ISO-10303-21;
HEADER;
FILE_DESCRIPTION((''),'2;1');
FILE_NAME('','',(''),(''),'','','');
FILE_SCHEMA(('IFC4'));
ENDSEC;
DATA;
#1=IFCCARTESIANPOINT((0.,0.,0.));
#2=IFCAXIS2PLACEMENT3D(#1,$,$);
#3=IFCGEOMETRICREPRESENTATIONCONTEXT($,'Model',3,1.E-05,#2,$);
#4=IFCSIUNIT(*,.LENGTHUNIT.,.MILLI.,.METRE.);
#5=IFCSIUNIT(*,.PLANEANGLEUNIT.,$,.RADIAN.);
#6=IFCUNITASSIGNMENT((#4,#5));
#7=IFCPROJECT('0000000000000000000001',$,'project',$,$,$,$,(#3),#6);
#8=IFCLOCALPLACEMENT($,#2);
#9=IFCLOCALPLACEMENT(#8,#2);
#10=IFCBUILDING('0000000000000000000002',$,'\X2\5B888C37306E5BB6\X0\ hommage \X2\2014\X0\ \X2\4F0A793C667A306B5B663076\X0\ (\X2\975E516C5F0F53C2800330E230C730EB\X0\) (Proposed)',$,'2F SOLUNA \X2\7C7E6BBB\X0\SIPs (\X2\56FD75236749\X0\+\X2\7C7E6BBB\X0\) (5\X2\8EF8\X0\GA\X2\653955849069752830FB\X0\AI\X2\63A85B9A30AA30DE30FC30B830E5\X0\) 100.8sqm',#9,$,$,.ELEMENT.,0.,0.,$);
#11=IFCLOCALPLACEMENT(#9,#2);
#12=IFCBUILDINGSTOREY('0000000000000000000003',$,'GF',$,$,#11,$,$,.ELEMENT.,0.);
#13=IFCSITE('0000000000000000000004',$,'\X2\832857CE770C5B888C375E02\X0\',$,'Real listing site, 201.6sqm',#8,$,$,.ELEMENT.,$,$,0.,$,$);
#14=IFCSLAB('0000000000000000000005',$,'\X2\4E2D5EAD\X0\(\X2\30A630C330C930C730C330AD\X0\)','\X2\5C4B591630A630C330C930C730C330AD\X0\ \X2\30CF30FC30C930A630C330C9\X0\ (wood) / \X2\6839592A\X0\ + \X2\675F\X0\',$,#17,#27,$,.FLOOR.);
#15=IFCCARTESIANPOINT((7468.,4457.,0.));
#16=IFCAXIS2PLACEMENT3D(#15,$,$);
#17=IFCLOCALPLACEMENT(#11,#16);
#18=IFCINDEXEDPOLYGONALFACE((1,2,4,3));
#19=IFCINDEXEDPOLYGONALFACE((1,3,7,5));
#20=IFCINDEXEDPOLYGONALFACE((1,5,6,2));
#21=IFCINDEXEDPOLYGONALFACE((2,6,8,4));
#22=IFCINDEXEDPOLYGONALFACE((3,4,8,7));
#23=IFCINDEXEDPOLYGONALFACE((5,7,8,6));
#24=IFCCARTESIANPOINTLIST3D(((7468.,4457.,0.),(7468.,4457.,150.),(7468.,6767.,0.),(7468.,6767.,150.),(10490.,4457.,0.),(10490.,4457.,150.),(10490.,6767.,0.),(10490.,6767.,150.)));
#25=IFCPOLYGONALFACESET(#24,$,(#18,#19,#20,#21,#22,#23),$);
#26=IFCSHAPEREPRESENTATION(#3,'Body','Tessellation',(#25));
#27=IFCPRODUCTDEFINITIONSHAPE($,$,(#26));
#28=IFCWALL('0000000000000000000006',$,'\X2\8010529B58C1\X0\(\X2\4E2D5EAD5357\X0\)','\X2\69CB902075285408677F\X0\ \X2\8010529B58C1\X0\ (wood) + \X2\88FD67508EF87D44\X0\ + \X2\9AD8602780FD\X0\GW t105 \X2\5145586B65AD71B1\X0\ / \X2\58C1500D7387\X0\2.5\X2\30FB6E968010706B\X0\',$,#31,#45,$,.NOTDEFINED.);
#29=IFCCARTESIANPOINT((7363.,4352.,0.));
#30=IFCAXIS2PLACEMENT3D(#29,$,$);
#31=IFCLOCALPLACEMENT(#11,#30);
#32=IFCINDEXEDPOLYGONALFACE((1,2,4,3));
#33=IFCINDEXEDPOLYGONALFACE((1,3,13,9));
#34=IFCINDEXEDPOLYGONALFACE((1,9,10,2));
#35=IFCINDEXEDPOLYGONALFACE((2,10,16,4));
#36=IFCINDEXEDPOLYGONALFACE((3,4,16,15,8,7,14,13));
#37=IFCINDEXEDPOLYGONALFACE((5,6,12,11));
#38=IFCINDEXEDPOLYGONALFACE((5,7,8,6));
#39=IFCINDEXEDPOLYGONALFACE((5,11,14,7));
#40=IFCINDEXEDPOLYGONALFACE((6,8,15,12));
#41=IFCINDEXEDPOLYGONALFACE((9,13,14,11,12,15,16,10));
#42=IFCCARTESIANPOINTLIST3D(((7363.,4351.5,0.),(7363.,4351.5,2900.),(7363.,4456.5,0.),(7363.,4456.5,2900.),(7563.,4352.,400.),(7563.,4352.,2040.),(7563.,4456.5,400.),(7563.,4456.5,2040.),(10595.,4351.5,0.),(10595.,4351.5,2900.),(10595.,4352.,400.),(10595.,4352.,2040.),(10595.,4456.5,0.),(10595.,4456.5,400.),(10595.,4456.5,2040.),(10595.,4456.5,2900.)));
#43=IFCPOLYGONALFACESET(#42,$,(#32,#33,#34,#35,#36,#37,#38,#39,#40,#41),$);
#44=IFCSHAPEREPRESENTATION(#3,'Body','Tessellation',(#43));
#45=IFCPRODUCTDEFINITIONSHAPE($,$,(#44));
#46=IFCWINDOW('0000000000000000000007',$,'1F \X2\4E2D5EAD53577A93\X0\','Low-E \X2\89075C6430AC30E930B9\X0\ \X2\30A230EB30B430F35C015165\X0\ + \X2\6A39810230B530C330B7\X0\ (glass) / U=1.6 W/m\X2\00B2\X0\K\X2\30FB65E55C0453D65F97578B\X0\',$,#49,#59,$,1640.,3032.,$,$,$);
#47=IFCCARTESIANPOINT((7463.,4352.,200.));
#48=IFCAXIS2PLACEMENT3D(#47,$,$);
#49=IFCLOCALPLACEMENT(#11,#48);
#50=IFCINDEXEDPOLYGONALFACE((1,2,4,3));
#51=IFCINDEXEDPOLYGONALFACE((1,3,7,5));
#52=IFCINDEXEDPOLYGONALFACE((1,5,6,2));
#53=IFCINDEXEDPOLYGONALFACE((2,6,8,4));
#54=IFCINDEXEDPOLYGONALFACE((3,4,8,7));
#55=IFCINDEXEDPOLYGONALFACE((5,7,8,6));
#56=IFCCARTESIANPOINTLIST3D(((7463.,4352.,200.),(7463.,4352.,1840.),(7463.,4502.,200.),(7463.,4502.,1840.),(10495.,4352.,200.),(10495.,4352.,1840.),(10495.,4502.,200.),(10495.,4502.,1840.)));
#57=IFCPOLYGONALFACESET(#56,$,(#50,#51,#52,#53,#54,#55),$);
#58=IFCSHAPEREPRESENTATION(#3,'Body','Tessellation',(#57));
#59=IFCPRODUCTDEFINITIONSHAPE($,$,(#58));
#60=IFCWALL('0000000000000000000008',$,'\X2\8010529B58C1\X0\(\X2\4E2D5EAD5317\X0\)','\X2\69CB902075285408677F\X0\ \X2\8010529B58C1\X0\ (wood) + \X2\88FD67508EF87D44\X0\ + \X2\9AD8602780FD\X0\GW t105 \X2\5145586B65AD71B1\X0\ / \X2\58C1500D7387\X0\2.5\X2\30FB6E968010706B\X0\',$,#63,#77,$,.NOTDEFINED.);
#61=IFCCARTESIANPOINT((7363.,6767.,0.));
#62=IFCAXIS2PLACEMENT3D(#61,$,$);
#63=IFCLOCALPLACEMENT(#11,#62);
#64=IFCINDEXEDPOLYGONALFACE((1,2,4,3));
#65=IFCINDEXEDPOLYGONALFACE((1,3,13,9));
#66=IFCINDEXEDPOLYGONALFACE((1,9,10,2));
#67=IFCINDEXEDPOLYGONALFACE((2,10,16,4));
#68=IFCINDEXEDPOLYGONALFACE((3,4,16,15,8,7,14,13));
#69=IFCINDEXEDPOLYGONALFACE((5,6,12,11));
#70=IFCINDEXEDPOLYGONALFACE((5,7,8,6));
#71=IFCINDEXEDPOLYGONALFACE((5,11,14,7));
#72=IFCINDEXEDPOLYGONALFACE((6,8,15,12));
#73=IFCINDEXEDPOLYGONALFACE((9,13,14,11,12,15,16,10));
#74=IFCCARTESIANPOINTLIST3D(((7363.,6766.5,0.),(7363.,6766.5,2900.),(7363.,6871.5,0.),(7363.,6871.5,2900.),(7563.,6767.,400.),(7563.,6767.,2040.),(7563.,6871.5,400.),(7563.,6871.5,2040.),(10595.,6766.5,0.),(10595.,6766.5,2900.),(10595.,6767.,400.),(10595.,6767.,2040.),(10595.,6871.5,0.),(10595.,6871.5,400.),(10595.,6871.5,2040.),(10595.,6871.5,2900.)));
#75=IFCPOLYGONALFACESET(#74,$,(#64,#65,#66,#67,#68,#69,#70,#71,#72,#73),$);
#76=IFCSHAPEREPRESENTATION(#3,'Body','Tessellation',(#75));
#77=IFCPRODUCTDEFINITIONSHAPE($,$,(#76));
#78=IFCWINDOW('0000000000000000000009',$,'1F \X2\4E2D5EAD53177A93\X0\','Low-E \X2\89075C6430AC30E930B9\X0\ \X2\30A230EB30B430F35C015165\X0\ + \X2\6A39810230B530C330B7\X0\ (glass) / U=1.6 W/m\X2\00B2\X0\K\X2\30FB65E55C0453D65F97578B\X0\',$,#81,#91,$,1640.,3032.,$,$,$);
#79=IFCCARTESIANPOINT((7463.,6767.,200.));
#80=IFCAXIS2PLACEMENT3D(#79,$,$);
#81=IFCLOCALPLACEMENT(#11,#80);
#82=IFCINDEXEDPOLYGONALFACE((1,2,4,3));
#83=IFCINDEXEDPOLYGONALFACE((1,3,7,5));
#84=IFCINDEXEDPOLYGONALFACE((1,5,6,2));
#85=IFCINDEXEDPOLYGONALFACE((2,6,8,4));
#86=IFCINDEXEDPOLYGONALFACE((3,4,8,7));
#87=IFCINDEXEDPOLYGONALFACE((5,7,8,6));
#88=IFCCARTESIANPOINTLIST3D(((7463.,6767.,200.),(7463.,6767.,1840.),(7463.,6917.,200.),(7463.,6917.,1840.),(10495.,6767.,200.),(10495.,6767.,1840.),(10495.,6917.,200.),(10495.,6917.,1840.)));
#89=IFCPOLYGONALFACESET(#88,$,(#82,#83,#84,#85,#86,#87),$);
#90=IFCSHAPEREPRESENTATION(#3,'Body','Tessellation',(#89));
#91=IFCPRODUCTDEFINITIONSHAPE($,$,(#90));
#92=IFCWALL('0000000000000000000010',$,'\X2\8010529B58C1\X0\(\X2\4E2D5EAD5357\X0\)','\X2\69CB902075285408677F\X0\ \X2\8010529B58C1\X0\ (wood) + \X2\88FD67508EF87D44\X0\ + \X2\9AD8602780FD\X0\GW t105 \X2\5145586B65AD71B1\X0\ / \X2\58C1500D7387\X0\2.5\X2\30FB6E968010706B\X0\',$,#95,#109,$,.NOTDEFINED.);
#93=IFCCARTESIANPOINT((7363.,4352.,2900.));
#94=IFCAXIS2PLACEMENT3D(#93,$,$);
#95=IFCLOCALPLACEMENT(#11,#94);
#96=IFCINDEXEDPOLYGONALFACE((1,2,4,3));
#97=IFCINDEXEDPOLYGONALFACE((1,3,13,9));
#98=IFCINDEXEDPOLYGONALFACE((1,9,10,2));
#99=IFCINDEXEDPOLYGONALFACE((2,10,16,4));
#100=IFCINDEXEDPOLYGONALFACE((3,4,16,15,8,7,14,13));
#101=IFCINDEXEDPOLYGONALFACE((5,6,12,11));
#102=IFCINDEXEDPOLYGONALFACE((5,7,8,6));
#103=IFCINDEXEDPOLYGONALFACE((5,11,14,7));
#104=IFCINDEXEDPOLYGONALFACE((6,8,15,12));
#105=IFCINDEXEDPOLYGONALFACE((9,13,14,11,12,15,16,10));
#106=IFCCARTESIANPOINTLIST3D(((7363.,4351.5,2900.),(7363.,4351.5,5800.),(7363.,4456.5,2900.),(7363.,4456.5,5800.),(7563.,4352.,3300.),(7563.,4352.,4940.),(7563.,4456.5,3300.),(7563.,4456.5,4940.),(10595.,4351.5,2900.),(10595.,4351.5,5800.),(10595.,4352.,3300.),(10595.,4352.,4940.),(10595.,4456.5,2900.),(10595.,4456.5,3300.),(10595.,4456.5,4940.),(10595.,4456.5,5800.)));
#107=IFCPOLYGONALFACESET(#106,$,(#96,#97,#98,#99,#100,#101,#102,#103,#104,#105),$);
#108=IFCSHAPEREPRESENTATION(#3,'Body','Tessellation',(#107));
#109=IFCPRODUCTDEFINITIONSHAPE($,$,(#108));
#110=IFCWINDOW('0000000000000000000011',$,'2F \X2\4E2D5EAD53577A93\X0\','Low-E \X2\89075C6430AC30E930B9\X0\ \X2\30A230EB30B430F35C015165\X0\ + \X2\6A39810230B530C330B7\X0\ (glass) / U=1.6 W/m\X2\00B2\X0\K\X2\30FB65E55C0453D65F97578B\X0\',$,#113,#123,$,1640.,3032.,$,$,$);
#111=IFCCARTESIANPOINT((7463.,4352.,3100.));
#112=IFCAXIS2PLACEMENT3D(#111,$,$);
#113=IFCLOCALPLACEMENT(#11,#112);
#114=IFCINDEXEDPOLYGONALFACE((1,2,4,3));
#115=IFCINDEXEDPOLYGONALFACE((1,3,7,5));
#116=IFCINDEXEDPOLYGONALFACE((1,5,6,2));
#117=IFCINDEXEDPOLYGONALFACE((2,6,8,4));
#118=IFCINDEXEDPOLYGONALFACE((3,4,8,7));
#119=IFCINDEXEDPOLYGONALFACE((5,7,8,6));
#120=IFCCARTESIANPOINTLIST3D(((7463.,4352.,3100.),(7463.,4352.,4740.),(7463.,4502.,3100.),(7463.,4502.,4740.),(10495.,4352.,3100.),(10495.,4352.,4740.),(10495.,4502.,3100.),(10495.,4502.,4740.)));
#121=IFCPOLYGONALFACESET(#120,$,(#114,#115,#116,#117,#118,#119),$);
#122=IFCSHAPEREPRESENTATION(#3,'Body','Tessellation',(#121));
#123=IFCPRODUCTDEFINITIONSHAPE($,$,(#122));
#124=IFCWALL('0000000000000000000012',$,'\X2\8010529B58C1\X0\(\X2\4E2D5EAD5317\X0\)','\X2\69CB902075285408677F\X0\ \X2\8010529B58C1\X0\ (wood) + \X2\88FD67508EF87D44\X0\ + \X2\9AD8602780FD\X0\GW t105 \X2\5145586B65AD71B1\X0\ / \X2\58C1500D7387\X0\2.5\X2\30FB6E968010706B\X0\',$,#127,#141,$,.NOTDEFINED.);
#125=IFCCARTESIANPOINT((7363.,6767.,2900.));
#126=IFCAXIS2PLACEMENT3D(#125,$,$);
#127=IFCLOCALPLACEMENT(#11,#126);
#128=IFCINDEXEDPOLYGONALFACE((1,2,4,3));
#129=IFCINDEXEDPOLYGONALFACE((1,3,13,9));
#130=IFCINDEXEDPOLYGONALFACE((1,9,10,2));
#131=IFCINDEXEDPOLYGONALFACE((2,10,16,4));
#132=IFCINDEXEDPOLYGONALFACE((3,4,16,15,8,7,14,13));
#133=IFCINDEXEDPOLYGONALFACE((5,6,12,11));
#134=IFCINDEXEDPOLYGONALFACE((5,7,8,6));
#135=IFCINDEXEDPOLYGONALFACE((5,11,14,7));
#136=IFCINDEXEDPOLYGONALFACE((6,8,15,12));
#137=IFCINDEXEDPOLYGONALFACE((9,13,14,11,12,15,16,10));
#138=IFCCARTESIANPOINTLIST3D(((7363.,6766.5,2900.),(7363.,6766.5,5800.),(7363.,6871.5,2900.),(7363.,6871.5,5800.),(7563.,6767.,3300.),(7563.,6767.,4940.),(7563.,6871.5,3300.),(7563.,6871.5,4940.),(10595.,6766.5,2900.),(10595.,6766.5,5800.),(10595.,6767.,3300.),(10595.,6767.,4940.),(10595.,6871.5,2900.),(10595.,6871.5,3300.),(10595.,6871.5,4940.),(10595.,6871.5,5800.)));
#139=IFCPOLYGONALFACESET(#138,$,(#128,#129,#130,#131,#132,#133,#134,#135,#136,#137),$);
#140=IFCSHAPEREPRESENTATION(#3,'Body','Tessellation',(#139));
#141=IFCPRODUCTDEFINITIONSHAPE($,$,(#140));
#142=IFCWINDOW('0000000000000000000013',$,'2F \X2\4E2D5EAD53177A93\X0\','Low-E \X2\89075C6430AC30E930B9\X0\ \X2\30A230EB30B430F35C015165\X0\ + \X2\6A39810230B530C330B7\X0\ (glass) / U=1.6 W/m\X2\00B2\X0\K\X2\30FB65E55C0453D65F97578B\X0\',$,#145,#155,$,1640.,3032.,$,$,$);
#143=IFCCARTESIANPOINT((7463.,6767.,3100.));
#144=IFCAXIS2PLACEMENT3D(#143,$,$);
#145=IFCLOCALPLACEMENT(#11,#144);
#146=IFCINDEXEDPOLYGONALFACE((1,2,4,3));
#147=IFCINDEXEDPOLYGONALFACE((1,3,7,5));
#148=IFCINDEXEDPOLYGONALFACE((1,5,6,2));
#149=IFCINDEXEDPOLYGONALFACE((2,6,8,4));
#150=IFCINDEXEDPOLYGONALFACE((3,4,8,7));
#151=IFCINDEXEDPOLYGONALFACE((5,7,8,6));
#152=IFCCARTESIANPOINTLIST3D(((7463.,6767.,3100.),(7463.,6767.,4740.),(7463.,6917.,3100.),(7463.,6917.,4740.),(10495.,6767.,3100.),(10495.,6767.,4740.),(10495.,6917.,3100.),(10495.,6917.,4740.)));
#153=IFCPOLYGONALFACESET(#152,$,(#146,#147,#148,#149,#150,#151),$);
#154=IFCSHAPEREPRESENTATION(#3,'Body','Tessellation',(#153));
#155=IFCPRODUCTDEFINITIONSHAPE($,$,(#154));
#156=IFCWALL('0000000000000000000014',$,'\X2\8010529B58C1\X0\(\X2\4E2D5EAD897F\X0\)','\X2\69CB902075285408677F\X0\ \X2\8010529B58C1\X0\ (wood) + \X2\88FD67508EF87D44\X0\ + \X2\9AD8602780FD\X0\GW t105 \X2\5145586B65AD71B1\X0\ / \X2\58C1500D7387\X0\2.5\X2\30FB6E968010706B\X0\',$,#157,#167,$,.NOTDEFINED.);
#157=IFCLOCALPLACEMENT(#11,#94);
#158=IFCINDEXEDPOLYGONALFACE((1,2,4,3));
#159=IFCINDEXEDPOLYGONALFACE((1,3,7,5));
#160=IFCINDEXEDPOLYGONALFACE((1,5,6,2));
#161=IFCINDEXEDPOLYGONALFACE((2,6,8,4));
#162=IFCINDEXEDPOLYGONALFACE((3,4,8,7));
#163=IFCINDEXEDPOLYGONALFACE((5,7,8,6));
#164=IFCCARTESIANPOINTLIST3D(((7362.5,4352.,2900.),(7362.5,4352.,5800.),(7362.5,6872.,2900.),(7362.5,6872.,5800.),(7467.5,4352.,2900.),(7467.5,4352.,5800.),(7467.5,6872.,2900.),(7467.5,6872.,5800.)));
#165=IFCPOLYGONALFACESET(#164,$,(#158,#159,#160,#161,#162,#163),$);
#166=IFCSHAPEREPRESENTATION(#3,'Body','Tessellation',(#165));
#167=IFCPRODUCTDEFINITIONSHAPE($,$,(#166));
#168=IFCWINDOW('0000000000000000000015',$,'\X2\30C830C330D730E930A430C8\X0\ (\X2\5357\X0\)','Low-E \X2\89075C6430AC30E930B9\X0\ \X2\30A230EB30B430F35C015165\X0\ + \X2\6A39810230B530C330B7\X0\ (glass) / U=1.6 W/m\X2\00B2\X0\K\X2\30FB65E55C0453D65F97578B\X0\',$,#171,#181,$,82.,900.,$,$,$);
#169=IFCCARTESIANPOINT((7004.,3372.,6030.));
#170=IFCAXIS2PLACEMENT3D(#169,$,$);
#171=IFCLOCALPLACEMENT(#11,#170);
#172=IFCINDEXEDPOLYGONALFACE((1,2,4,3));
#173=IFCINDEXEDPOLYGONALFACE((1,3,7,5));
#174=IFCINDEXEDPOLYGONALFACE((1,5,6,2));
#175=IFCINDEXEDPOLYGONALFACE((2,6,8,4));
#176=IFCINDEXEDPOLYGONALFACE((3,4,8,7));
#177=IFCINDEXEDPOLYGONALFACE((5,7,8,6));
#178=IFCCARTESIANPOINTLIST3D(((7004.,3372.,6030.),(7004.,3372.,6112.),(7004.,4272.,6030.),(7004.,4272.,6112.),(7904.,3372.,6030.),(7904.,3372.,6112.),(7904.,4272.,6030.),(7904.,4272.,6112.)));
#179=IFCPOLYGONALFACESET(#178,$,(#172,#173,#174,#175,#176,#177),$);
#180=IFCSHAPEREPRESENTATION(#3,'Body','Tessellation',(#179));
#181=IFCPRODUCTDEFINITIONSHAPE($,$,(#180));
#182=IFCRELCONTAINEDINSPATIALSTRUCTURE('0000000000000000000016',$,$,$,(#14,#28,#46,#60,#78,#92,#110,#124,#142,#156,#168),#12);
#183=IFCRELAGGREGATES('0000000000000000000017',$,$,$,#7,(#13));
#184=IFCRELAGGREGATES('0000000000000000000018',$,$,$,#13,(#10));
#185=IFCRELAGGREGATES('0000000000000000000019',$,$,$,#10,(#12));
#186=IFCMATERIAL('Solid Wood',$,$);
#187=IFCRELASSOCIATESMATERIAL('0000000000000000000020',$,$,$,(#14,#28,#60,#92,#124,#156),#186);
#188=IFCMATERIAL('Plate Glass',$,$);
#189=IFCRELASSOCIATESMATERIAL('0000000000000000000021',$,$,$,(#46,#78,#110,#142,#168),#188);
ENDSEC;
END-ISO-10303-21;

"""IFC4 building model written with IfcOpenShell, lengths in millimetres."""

from ifc_helpers import new_model, si_unit, frame, frame_2d, origin, place, context, project, spatial, rectangle, extrude, material, element, fill, save


model = new_model("IFC4")

# Units and contexts
model_context = context("Model", 3, precision=1e-05, world=origin())
ifc_project = project(units=[si_unit("LENGTHUNIT", "METRE", prefix="MILLI"), si_unit("PLANEANGLEUNIT", "RADIAN")], contexts=[model_context])

# Site, building, storey
site_placement = place(None, origin())
site = spatial("IfcSite", under=ifc_project, at=site_placement, Name="茨城県守谷市", ObjectType="Real listing site, 201.6sqm", CompositionType="ELEMENT", RefElevation=0.0)
building_placement = place(site_placement, origin())
building = spatial("IfcBuilding", under=site, at=building_placement, Name="守谷の家 hommage — 伊礼智に学ぶ (非公式参考モデル) (Proposed)", ObjectType="2F SOLUNA 籾殻SIPs (国産杉+籾殻) (5軸GA改善適用・AI推定オマージュ) 100.8sqm", CompositionType="ELEMENT", ElevationOfRefHeight=0.0, ElevationOfTerrain=0.0)
storey_placement = place(building_placement, origin())
storey = spatial("IfcBuildingStorey", under=building, at=storey_placement, Name="GF", CompositionType="ELEMENT", Elevation=0.0)

# Slab
ifc_material_1 = material(Name="Solid Wood")
slab_placement = place(storey_placement, frame((7468.0, 4457.0, 0.0)))
element("IfcSlab", 1, at=slab_placement, inside=storey, material=ifc_material_1, Name="中庭(ウッドデッキ)", Description="屋外ウッドデッキ ハードウッド (wood) / 根太 + 束", PredefinedType="FLOOR", context=model_context, shape_type="SweptSolid", body=[
    extrude(rectangle(XDim=3022.0, YDim=2310.0, at=frame_2d((1511.0, 1155.0))), frame((7468.0, 4457.0, 0.0)), (0.0, 0.0, 1.0), 150.0),
])

# Walls, openings, windows
wall_1_placement = place(storey_placement, frame((7363.0, 4352.0, 0.0)))
wall_1 = element("IfcWall", 2, at=wall_1_placement, inside=storey, material=ifc_material_1, Name="耐力壁(中庭南)", Description="構造用合板 耐力壁 (wood) + 製材軸組 + 高性能GW t105 充填断熱 / 壁倍率2.5・準耐火", PredefinedType="NOTDEFINED", context=model_context, shape_type="SweptSolid", body=[
    extrude(rectangle(XDim=3232.0, YDim=105.0, at=frame_2d((1616.0, 52.0))), frame((7363.0, 4352.0, 0.0)), (0.0, 0.0, 1.0), 2900.0),
])
opening_1_placement = place(storey_placement, frame((7463.0, 4352.0, 200.0)))
opening_1 = element("IfcOpeningElement", 3, at=opening_1_placement, cuts=wall_1, PredefinedType="NOTDEFINED", context=model_context, shape_type="SweptSolid", body=[
    extrude(rectangle(XDim=3032.0, YDim=150.0, at=frame_2d((1516.0, 75.0))), frame((7463.0, 4352.0, 200.0)), (0.0, 0.0, 1.0), 1640.0),
])
ifc_material_2 = material(Name="Plate Glass")
window_1_placement = place(storey_placement, frame((7463.0, 4352.0, 200.0)))
window_1 = element("IfcWindow", 4, at=window_1_placement, inside=storey, material=ifc_material_2, Name="1F 中庭南窓", Description="Low-E 複層ガラス アルゴン封入 + 樹脂サッシ (glass) / U=1.6 W/m²K・日射取得型", OverallHeight=1640.0, OverallWidth=3032.0, context=model_context, shape_type="SweptSolid", body=[
    extrude(rectangle(XDim=3032.0, YDim=150.0, at=frame_2d((1516.0, 75.0))), frame((7463.0, 4352.0, 200.0)), (0.0, 0.0, 1.0), 1640.0),
])
fill(opening_1, window_1)
wall_2_placement = place(storey_placement, frame((7363.0, 6767.0, 0.0)))
wall_2 = element("IfcWall", 5, at=wall_2_placement, inside=storey, material=ifc_material_1, Name="耐力壁(中庭北)", Description="構造用合板 耐力壁 (wood) + 製材軸組 + 高性能GW t105 充填断熱 / 壁倍率2.5・準耐火", PredefinedType="NOTDEFINED", context=model_context, shape_type="SweptSolid", body=[
    extrude(rectangle(XDim=3232.0, YDim=105.0, at=frame_2d((1616.0, 52.0))), frame((7363.0, 6767.0, 0.0)), (0.0, 0.0, 1.0), 2900.0),
])
opening_2_placement = place(storey_placement, frame((7463.0, 6767.0, 200.0)))
opening_2 = element("IfcOpeningElement", 6, at=opening_2_placement, cuts=wall_2, PredefinedType="NOTDEFINED", context=model_context, shape_type="SweptSolid", body=[
    extrude(rectangle(XDim=3032.0, YDim=150.0, at=frame_2d((1516.0, 75.0))), frame((7463.0, 6767.0, 200.0)), (0.0, 0.0, 1.0), 1640.0),
])
window_2_placement = place(storey_placement, frame((7463.0, 6767.0, 200.0)))
window_2 = element("IfcWindow", 7, at=window_2_placement, inside=storey, material=ifc_material_2, Name="1F 中庭北窓", Description="Low-E 複層ガラス アルゴン封入 + 樹脂サッシ (glass) / U=1.6 W/m²K・日射取得型", OverallHeight=1640.0, OverallWidth=3032.0, context=model_context, shape_type="SweptSolid", body=[
    extrude(rectangle(XDim=3032.0, YDim=150.0, at=frame_2d((1516.0, 75.0))), frame((7463.0, 6767.0, 200.0)), (0.0, 0.0, 1.0), 1640.0),
])
fill(opening_2, window_2)

# Walls, openings, windows
wall_3_placement = place(storey_placement, frame((7363.0, 4352.0, 2900.0)))
wall_3 = element("IfcWall", 8, at=wall_3_placement, inside=storey, material=ifc_material_1, Name="耐力壁(中庭南)", Description="構造用合板 耐力壁 (wood) + 製材軸組 + 高性能GW t105 充填断熱 / 壁倍率2.5・準耐火", PredefinedType="NOTDEFINED", context=model_context, shape_type="SweptSolid", body=[
    extrude(rectangle(XDim=3232.0, YDim=105.0, at=frame_2d((1616.0, 52.0))), frame((7363.0, 4352.0, 2900.0)), (0.0, 0.0, 1.0), 2900.0),
])
opening_3_placement = place(storey_placement, frame((7463.0, 4352.0, 3100.0)))
opening_3 = element("IfcOpeningElement", 9, at=opening_3_placement, cuts=wall_3, PredefinedType="NOTDEFINED", context=model_context, shape_type="SweptSolid", body=[
    extrude(rectangle(XDim=3032.0, YDim=150.0, at=frame_2d((1516.0, 75.0))), frame((7463.0, 4352.0, 3100.0)), (0.0, 0.0, 1.0), 1640.0),
])
window_3_placement = place(storey_placement, frame((7463.0, 4352.0, 3100.0)))
window_3 = element("IfcWindow", 10, at=window_3_placement, inside=storey, material=ifc_material_2, Name="2F 中庭南窓", Description="Low-E 複層ガラス アルゴン封入 + 樹脂サッシ (glass) / U=1.6 W/m²K・日射取得型", OverallHeight=1640.0, OverallWidth=3032.0, context=model_context, shape_type="SweptSolid", body=[
    extrude(rectangle(XDim=3032.0, YDim=150.0, at=frame_2d((1516.0, 75.0))), frame((7463.0, 4352.0, 3100.0)), (0.0, 0.0, 1.0), 1640.0),
])
fill(opening_3, window_3)
wall_4_placement = place(storey_placement, frame((7363.0, 6767.0, 2900.0)))
wall_4 = element("IfcWall", 11, at=wall_4_placement, inside=storey, material=ifc_material_1, Name="耐力壁(中庭北)", Description="構造用合板 耐力壁 (wood) + 製材軸組 + 高性能GW t105 充填断熱 / 壁倍率2.5・準耐火", PredefinedType="NOTDEFINED", context=model_context, shape_type="SweptSolid", body=[
    extrude(rectangle(XDim=3232.0, YDim=105.0, at=frame_2d((1616.0, 52.0))), frame((7363.0, 6767.0, 2900.0)), (0.0, 0.0, 1.0), 2900.0),
])
opening_4_placement = place(storey_placement, frame((7463.0, 6767.0, 3100.0)))
opening_4 = element("IfcOpeningElement", 12, at=opening_4_placement, cuts=wall_4, PredefinedType="NOTDEFINED", context=model_context, shape_type="SweptSolid", body=[
    extrude(rectangle(XDim=3032.0, YDim=150.0, at=frame_2d((1516.0, 75.0))), frame((7463.0, 6767.0, 3100.0)), (0.0, 0.0, 1.0), 1640.0),
])
window_4_placement = place(storey_placement, frame((7463.0, 6767.0, 3100.0)))
window_4 = element("IfcWindow", 13, at=window_4_placement, inside=storey, material=ifc_material_2, Name="2F 中庭北窓", Description="Low-E 複層ガラス アルゴン封入 + 樹脂サッシ (glass) / U=1.6 W/m²K・日射取得型", OverallHeight=1640.0, OverallWidth=3032.0, context=model_context, shape_type="SweptSolid", body=[
    extrude(rectangle(XDim=3032.0, YDim=150.0, at=frame_2d((1516.0, 75.0))), frame((7463.0, 6767.0, 3100.0)), (0.0, 0.0, 1.0), 1640.0),
])
fill(opening_4, window_4)

# Wall
wall_5_placement = place(storey_placement, frame((7363.0, 4352.0, 2900.0)))
element("IfcWall", 14, at=wall_5_placement, inside=storey, material=ifc_material_1, Name="耐力壁(中庭西)", Description="構造用合板 耐力壁 (wood) + 製材軸組 + 高性能GW t105 充填断熱 / 壁倍率2.5・準耐火", PredefinedType="NOTDEFINED", context=model_context, shape_type="SweptSolid", body=[
    extrude(rectangle(XDim=105.0, YDim=2520.0, at=frame_2d((52.0, 1260.0))), frame((7363.0, 4352.0, 2900.0)), (0.0, 0.0, 1.0), 2900.0),
])

# Window
window_5_placement = place(storey_placement, frame((7004.0, 3372.0, 6030.0)))
element("IfcWindow", 15, at=window_5_placement, inside=storey, material=ifc_material_2, Name="トップライト (南)", Description="Low-E 複層ガラス アルゴン封入 + 樹脂サッシ (glass) / U=1.6 W/m²K・日射取得型", OverallHeight=82.0, OverallWidth=900.0, context=model_context, shape_type="SweptSolid", body=[
    extrude(rectangle(XDim=900.0, YDim=900.0, at=frame_2d((450.0, 450.0))), frame((7004.0, 3372.0, 6030.0)), (0.0, 0.0, 1.0), 82.0),
])

save(model, "model.ifc")
